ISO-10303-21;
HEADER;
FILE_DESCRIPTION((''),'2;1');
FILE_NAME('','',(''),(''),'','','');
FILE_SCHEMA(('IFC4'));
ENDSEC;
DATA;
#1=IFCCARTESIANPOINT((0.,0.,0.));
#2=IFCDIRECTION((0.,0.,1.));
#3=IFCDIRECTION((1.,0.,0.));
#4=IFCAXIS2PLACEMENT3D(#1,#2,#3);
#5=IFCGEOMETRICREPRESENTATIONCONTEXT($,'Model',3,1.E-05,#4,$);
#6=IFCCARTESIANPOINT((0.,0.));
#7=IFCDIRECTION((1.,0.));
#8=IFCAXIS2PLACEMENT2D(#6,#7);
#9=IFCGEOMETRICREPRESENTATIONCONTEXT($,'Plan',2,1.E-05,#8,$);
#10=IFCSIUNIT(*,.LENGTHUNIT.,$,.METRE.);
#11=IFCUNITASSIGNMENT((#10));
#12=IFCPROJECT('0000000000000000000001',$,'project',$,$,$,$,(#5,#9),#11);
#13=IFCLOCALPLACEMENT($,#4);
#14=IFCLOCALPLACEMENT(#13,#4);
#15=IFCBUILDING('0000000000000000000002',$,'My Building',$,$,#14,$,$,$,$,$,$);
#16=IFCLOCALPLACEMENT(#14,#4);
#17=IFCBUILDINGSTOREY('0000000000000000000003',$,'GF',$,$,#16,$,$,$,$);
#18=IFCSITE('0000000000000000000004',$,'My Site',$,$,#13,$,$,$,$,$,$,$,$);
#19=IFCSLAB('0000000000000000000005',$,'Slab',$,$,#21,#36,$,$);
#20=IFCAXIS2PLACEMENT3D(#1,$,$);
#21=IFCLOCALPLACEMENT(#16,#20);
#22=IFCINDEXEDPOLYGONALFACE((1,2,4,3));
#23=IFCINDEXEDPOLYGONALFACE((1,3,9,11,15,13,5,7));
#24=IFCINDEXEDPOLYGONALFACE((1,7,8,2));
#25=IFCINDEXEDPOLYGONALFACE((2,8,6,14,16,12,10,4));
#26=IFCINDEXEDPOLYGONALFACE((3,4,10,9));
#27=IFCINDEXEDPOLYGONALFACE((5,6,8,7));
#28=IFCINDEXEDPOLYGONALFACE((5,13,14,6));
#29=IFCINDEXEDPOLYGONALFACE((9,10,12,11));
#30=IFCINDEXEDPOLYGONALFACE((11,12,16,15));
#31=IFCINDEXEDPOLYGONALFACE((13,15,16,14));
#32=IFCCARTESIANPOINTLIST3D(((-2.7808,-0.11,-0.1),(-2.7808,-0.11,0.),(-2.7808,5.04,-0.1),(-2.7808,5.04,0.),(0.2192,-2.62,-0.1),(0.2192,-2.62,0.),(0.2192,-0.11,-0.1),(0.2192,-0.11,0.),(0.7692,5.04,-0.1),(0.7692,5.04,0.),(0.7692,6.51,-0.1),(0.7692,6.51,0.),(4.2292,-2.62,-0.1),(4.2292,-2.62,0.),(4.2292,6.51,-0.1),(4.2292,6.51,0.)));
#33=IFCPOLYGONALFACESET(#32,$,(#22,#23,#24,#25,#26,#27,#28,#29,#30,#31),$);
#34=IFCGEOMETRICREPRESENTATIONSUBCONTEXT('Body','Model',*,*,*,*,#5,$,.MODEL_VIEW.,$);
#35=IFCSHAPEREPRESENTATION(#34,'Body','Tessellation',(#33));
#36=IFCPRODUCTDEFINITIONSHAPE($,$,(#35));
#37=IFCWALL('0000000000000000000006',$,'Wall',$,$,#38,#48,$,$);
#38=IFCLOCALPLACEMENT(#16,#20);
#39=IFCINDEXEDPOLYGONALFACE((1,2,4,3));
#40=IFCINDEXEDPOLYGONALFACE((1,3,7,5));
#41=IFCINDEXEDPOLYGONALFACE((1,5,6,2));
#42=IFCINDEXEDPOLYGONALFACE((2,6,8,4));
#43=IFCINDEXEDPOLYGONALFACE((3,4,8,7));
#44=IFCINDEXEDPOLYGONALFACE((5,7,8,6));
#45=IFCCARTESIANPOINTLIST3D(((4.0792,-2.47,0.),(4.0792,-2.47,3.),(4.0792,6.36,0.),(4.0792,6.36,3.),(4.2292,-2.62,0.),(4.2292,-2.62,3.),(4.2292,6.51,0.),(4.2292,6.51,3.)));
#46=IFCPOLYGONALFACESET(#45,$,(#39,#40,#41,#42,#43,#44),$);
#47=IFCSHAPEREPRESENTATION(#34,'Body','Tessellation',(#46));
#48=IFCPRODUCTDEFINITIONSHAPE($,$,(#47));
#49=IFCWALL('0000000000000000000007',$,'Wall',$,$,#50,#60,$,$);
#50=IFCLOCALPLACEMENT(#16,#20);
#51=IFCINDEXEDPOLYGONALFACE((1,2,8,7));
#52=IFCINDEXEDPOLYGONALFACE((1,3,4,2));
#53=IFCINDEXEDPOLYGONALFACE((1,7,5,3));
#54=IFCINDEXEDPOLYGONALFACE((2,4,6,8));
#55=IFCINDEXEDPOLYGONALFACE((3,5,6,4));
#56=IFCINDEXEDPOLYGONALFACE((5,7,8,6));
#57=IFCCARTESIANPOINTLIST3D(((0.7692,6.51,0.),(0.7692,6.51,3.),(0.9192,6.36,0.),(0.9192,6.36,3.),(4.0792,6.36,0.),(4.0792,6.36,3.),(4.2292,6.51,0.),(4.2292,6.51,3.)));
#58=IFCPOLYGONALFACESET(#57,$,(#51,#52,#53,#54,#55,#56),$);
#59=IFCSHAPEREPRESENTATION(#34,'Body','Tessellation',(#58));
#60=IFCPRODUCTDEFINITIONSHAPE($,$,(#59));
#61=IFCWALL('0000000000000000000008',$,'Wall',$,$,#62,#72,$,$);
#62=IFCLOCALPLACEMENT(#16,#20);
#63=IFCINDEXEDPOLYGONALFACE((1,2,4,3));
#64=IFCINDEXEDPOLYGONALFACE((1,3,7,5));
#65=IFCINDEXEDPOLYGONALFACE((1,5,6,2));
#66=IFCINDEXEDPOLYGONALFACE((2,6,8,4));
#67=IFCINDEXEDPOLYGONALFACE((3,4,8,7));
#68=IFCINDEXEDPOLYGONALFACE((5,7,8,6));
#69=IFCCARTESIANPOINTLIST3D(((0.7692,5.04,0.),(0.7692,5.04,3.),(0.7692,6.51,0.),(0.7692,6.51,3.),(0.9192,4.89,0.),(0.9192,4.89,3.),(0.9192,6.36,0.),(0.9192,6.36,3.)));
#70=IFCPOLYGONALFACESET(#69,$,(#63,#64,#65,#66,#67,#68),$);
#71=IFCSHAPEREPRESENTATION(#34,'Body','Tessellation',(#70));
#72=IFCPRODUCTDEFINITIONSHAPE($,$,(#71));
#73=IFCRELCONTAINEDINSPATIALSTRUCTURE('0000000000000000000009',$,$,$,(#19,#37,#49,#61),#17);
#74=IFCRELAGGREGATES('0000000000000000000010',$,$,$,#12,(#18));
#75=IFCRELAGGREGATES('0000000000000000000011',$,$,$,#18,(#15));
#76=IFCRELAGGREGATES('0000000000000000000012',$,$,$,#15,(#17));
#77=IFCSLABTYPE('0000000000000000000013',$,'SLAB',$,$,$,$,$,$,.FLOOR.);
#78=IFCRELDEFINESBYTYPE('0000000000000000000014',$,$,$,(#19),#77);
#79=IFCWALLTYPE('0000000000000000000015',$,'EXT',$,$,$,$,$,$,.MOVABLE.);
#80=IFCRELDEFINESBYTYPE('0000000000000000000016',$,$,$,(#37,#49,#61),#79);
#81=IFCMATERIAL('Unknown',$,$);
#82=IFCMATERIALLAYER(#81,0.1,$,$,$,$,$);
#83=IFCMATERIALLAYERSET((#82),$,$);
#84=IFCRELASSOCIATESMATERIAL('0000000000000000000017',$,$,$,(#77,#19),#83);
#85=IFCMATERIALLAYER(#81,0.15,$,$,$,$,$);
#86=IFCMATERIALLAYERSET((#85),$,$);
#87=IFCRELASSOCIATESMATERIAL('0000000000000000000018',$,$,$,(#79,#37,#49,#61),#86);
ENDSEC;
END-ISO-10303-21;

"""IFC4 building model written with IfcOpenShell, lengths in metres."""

from ifc_helpers import new_model, si_unit, frame, origin_with_axes, origin_2d_with_axis, place, context, subcontext, project, spatial, line, indexed_curve, outline, extrude, material, layer, layer_set, layer_usage, type_object, element, save


model = new_model("IFC4")

# Units and contexts
model_context = context("Model", 3, precision=1e-05, world=origin_with_axes())
plan_context = context("Plan", 2, precision=1e-05, world=origin_2d_with_axis())
body_context_1 = subcontext(model_context, "Body", "Model", "MODEL_VIEW")
ifc_project = project(units=[si_unit("LENGTHUNIT", "METRE")], contexts=[model_context, plan_context])

# Site, building, storey
site_placement = place(None, origin_with_axes())
site = spatial("IfcSite", under=ifc_project, at=site_placement, Name="My Site")
building_placement = place(site_placement, origin_with_axes())
building = spatial("IfcBuilding", under=site, at=building_placement, Name="My Building")
storey_placement = place(building_placement, origin_with_axes())
storey = spatial("IfcBuildingStorey", under=building, at=storey_placement, Name="GF")

# Slab
ifc_material = material(Name="Unknown")
ifc_layer_1 = layer(ifc_material, 0.1)
ifc_layer_set_1 = layer_set([ifc_layer_1])
ifc_layer_usage_1 = layer_usage(ifc_layer_set_1, "AXIS3", "POSITIVE", -0.1)
slab_type = type_object("IfcSlabType", Name="SLAB", PredefinedType="FLOOR", material=ifc_layer_set_1)
slab_placement = place(storey_placement, frame((0.7692, 6.51, 0.0), z_axis=(0.0, 0.0, 1.0), x_axis=(1.0, 0.0, 0.0)))
element("IfcSlab", 1, at=slab_placement, inside=storey, type_object=slab_type, material=ifc_layer_usage_1, Name="Slab", context=body_context_1, shape_type="SweptSolid", body=[
    extrude(outline(indexed_curve([(0.0, 0.0), (3.46, 0.0), (3.46, -9.13), (-0.55, -9.13), (-0.55, -6.62), (-3.55, -6.62), (-3.55, -1.47), (0.0, -1.47), (0.0, 0.0)])), frame((0.0, 0.0, -0.1), z_axis=(0.0, 0.0, 1.0), x_axis=(1.0, 0.0, 0.0)), (0.0, 0.0, 1.0), 0.1),
])

# Shared definitions
ifc_layer_2 = layer(ifc_material, 0.15)
ifc_layer_set_2 = layer_set([ifc_layer_2])
wall_type_1 = type_object("IfcWallType", Name="EXT", PredefinedType="MOVABLE", material=ifc_layer_set_2)

# Walls
ifc_layer_usage_2 = layer_usage(ifc_layer_set_2, "AXIS2", "POSITIVE", 0.0)
wall_1_placement = place(storey_placement, frame((4.2292, -2.62, 0.0), z_axis=(0.0, 0.0, 1.0), x_axis=(0.0, 1.0, 0.0)))
element("IfcWall", 2, at=wall_1_placement, inside=storey, type_object=wall_type_1, material=ifc_layer_usage_2, Name="Wall", context=body_context_1, shape_type="SweptSolid", body=[
    extrude(outline(indexed_curve([(0.0, 0.0), (0.15, 0.15), (8.98, 0.15), (9.13, 0.0)], segments=[line(1, 2, 3, 4, 1)])), origin_with_axes(), (0.0, 0.0, 1.0), 3.0),
])
ifc_layer_usage_3 = layer_usage(ifc_layer_set_2, "AXIS2", "POSITIVE", 0.0)
wall_2_placement = place(storey_placement, frame((4.2292, 6.51, 0.0), z_axis=(0.0, 0.0, 1.0), x_axis=(-1.0, 0.0, 0.0)))
element("IfcWall", 3, at=wall_2_placement, inside=storey, type_object=wall_type_1, material=ifc_layer_usage_3, Name="Wall", context=body_context_1, shape_type="SweptSolid", body=[
    extrude(outline(indexed_curve([(0.0, 0.0), (0.15, 0.15), (3.31, 0.15), (3.46, 0.0)], segments=[line(1, 2, 3, 4, 1)])), origin_with_axes(), (0.0, 0.0, 1.0), 3.0),
])
ifc_layer_usage_4 = layer_usage(ifc_layer_set_2, "AXIS2", "POSITIVE", 0.0)
wall_3_placement = place(storey_placement, frame((0.7692, 6.51, 0.0), z_axis=(0.0, 0.0, 1.0), x_axis=(0.0, -1.0, 0.0)))
element("IfcWall", 4, at=wall_3_placement, inside=storey, type_object=wall_type_1, material=ifc_layer_usage_4, Name="Wall", context=body_context_1, shape_type="SweptSolid", body=[
    extrude(outline(indexed_curve([(0.0, 0.0), (0.15, 0.15), (1.62, 0.15), (1.47, 0.0)], segments=[line(1, 2, 3, 4, 1)])), origin_with_axes(), (0.0, 0.0, 1.0), 3.0),
])

save(model, "model.ifc")
